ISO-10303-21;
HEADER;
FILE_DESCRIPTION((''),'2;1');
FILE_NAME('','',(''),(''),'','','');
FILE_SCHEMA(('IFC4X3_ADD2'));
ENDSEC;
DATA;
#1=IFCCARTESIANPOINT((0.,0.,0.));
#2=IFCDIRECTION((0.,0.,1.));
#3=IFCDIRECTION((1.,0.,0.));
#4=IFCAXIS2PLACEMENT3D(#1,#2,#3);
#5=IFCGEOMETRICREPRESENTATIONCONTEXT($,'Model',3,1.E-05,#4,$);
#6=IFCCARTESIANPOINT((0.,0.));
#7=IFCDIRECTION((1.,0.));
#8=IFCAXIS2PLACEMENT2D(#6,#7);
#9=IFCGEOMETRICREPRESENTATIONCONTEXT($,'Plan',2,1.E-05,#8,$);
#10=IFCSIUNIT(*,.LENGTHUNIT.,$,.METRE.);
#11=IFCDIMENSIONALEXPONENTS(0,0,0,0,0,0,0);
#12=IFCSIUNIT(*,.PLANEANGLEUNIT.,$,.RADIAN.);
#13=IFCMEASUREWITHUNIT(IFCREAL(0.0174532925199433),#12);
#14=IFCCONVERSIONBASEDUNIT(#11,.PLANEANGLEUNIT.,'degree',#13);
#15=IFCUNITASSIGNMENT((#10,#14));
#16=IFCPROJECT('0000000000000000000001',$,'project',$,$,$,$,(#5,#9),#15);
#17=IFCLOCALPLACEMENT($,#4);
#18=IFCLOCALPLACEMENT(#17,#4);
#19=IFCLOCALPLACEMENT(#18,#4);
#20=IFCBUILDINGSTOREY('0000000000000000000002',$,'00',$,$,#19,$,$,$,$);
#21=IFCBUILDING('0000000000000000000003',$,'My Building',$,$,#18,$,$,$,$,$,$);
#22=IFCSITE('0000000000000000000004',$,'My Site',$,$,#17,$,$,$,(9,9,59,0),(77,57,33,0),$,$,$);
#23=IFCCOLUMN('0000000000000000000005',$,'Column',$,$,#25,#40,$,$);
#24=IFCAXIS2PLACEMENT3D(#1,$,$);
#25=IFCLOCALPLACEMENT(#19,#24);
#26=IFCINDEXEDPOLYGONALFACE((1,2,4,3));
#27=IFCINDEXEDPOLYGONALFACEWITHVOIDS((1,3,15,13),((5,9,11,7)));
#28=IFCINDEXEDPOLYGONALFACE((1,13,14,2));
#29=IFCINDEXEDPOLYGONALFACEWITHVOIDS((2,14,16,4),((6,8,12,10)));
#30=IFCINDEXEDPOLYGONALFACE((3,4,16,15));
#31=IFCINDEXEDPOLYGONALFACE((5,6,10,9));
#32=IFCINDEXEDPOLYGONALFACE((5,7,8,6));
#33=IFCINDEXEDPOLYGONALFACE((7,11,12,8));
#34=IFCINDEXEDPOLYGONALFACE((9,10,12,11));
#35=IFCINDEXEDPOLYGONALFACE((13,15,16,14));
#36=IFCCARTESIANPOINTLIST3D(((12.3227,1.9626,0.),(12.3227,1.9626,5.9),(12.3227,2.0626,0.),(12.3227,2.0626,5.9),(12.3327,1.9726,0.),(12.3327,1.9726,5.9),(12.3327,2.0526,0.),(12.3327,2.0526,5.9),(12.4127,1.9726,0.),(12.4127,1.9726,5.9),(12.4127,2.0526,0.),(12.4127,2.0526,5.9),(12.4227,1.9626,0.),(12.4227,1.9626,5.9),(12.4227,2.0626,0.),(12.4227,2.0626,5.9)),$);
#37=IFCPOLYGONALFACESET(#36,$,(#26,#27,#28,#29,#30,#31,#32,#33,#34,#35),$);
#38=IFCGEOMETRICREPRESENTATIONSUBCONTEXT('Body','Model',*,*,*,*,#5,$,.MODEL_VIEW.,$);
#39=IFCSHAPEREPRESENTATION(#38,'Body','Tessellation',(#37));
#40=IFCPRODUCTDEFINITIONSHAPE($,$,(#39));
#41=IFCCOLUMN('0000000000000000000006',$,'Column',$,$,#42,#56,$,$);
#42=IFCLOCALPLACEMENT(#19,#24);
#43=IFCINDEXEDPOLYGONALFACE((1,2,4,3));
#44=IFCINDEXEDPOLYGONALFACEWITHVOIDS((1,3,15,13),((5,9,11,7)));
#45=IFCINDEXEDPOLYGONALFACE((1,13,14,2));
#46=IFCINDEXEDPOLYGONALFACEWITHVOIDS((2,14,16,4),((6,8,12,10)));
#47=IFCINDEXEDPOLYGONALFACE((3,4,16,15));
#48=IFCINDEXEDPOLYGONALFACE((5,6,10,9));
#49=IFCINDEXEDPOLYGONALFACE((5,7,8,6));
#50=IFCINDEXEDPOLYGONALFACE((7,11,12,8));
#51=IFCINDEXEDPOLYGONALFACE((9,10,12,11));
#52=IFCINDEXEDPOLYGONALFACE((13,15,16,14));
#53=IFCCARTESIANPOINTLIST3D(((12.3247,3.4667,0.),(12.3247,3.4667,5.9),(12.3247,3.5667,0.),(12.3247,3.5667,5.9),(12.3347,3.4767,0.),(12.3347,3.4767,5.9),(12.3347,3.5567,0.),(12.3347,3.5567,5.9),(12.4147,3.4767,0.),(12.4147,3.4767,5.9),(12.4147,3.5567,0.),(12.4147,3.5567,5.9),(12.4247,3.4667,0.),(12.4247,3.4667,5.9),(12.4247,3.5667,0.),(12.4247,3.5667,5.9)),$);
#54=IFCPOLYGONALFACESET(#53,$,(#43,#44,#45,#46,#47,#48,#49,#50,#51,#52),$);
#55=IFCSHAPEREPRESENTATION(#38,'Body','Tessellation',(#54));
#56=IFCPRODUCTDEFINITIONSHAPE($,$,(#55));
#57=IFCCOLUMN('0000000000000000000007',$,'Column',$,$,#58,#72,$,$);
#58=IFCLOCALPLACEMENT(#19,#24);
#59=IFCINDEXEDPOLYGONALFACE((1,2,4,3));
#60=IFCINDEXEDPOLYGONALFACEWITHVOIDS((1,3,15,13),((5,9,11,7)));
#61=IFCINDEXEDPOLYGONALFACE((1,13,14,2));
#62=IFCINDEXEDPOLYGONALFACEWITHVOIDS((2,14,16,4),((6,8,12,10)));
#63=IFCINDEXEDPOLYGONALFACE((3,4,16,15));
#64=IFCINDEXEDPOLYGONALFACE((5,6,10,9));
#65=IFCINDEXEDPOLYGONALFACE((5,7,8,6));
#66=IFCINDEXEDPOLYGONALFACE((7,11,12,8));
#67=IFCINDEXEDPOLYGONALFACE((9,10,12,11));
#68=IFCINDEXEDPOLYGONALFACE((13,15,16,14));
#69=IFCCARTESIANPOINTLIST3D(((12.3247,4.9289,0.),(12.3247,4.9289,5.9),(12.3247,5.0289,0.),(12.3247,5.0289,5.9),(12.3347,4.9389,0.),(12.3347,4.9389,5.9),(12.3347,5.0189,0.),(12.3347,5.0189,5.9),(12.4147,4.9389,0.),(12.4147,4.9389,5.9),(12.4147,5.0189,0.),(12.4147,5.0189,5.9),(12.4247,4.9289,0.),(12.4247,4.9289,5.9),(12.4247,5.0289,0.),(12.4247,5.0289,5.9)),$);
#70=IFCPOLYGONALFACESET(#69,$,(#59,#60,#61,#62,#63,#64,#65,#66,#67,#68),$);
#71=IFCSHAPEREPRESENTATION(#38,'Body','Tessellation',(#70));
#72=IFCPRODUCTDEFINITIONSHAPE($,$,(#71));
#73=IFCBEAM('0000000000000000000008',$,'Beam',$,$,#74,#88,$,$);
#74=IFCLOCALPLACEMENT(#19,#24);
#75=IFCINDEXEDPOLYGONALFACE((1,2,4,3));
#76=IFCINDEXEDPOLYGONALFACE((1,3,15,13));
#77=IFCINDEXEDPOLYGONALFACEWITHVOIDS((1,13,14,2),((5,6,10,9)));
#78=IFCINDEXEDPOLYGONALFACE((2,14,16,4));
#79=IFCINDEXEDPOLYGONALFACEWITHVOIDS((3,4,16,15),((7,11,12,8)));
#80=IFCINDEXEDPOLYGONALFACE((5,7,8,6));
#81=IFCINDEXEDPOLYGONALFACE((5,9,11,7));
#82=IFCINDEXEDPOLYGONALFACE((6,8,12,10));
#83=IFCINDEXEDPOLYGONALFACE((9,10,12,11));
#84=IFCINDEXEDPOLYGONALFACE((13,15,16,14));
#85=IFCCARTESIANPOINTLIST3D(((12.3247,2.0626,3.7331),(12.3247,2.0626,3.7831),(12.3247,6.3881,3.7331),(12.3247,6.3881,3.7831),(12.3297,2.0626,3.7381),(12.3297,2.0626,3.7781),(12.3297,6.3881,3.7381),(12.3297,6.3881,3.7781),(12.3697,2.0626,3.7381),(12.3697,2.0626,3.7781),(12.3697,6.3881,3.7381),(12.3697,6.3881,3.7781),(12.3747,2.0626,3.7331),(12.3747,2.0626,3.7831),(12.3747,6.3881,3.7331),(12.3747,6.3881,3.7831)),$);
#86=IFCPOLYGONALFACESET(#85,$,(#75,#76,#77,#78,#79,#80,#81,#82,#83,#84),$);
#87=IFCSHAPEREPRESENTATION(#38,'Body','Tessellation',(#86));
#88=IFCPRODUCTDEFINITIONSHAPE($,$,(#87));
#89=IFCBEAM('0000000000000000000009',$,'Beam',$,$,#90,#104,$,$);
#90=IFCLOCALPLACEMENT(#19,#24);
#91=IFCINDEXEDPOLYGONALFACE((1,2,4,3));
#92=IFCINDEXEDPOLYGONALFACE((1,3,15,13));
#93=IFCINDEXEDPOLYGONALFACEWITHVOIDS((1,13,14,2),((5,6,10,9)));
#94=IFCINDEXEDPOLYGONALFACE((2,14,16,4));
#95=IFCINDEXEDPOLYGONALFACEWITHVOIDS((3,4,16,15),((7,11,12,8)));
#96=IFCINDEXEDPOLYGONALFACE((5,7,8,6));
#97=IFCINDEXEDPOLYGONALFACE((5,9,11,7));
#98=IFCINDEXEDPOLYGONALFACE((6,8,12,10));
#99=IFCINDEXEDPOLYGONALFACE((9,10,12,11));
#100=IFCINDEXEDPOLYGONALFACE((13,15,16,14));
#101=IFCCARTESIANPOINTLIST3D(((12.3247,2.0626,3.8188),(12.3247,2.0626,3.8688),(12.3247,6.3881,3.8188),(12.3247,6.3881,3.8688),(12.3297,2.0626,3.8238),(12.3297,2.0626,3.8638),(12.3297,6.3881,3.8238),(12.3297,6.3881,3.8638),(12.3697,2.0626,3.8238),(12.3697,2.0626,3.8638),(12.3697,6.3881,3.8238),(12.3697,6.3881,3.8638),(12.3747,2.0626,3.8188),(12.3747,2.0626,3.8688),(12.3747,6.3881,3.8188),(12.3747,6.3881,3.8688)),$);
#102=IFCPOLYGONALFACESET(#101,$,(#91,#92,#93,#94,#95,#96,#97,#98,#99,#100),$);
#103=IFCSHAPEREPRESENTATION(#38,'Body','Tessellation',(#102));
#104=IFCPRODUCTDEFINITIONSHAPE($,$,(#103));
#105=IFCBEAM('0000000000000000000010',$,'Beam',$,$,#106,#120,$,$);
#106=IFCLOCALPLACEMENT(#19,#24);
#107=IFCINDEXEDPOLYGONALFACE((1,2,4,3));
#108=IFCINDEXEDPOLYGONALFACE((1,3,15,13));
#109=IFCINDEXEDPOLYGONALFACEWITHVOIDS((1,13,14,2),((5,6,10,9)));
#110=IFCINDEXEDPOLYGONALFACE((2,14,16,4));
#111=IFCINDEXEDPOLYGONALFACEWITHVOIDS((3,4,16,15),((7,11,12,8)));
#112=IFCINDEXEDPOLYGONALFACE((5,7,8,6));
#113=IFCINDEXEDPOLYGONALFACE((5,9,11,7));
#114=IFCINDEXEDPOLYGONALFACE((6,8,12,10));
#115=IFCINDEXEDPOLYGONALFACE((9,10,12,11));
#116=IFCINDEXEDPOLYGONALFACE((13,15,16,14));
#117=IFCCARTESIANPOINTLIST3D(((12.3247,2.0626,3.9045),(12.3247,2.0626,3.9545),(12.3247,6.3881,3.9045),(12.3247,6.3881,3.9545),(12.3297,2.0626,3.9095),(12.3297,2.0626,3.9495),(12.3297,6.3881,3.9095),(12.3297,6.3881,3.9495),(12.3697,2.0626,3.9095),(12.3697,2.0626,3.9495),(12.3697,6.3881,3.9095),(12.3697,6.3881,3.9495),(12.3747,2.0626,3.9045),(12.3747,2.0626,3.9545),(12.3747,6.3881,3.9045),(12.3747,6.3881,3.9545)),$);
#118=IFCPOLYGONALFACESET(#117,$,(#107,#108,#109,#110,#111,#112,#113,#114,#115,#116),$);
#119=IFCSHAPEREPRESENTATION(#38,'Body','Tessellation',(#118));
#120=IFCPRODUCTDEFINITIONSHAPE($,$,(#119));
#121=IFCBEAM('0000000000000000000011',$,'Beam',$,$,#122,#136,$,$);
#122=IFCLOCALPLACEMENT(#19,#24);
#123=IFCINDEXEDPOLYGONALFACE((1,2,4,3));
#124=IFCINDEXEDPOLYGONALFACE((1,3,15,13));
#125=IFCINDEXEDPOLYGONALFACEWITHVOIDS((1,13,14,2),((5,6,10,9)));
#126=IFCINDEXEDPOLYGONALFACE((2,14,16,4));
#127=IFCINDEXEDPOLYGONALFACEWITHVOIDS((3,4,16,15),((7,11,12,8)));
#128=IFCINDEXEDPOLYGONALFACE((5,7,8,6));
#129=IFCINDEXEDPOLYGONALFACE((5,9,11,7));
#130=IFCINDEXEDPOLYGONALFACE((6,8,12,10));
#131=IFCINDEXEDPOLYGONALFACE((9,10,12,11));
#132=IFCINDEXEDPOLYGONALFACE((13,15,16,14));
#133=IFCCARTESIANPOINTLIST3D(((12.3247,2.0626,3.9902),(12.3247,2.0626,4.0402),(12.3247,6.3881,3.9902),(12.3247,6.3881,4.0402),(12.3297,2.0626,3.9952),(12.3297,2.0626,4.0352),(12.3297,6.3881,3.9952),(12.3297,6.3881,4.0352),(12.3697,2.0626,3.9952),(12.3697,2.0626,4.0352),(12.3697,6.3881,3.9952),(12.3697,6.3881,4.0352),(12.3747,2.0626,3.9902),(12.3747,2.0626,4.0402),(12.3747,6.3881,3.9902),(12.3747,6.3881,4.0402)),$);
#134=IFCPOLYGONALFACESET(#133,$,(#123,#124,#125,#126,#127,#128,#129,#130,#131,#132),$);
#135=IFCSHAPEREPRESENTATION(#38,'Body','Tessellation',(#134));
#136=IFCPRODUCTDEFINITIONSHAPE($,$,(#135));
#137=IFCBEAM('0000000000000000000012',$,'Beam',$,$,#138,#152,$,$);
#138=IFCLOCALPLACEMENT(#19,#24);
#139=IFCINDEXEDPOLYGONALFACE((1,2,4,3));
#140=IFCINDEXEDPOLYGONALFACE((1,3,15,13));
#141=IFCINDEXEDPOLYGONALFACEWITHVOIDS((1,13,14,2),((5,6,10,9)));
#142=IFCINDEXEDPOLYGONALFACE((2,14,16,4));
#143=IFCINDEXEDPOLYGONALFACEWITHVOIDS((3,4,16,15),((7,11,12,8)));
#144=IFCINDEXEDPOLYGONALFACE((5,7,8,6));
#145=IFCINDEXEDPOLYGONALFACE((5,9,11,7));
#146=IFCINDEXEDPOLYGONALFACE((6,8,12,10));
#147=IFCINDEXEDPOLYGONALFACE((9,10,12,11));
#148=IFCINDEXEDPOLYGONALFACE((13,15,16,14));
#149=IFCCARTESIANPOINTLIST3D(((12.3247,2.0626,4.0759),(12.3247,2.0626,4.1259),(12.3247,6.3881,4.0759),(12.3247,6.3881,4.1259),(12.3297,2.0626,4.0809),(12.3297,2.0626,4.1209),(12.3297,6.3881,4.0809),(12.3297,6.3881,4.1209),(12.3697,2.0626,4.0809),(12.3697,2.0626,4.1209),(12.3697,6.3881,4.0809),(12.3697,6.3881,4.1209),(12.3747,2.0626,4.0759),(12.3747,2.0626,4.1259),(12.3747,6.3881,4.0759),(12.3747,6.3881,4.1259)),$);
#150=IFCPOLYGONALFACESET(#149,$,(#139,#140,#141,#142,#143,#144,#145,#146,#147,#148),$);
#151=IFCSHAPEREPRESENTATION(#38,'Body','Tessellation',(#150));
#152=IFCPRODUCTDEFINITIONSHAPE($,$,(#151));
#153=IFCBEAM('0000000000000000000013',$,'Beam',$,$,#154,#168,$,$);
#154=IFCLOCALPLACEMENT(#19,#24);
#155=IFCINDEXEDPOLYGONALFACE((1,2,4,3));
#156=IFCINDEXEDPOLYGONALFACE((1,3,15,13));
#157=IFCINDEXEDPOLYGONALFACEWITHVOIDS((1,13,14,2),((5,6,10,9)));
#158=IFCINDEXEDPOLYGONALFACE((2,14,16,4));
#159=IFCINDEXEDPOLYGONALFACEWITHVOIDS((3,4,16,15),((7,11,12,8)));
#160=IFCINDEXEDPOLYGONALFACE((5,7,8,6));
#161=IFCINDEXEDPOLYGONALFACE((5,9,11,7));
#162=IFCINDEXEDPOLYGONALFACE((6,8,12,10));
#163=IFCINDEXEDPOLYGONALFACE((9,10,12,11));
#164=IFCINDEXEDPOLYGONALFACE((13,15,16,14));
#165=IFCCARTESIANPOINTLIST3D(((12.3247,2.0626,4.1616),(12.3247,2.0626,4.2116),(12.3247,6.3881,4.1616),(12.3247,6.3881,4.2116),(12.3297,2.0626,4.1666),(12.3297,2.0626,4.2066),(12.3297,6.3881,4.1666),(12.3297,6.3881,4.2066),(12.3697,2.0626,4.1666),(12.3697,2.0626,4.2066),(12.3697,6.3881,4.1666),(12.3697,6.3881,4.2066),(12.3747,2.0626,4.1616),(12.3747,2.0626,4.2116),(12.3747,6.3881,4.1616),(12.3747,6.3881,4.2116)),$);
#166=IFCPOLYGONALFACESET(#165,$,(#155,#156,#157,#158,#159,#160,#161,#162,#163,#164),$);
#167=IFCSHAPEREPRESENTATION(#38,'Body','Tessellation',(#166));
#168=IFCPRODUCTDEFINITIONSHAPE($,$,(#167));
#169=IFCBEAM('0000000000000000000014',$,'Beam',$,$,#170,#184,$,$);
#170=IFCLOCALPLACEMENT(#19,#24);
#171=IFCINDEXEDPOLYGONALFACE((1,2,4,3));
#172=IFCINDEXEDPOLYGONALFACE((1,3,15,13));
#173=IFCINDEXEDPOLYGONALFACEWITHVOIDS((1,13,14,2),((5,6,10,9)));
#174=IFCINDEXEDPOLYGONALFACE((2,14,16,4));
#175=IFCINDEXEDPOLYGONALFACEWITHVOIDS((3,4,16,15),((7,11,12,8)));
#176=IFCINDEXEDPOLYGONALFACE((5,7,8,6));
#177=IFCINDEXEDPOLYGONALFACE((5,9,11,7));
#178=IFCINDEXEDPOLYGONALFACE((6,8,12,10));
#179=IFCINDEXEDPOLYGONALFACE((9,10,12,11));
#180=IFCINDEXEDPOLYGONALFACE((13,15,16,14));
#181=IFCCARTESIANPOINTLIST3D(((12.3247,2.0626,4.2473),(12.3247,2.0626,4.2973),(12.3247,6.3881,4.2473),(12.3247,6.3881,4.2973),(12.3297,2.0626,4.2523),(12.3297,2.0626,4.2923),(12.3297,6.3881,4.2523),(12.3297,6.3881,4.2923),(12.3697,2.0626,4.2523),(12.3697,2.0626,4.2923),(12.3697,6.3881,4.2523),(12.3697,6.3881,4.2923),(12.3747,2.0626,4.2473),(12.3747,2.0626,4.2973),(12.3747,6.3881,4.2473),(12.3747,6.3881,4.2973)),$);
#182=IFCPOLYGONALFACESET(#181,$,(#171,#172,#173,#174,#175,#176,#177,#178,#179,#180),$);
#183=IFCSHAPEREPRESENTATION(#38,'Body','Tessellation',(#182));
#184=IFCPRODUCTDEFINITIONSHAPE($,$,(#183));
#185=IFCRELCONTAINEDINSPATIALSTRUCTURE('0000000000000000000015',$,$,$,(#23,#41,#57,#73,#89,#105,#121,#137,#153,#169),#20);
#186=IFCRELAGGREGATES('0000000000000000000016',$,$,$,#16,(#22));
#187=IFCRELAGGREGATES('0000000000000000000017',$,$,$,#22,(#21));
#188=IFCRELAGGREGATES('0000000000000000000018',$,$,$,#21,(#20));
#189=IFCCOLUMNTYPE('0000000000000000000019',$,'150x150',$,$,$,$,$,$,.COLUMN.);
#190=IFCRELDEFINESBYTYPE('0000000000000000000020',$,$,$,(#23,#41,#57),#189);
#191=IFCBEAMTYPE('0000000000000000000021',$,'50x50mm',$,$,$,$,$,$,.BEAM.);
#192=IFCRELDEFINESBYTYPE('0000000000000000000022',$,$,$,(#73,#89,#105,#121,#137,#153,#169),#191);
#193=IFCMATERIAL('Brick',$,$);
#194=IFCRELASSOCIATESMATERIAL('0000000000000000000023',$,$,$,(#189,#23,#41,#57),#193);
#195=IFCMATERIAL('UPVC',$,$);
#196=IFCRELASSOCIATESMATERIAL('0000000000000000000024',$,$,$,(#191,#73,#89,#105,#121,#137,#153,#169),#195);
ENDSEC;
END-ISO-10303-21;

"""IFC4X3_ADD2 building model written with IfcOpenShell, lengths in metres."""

from ifc_helpers import new_model, entity, si_unit, converted_unit, frame, origin_with_axes, origin_2d_with_axis, place, context, subcontext, project, spatial, hollow_rectangle, extrude, material, material_profile, profile_set, profile_usage, type_object, element, save


model = new_model("IFC4X3_ADD2")

# Units and contexts
model_context = context("Model", 3, precision=1e-05, world=origin_with_axes())
plan_context = context("Plan", 2, precision=1e-05, world=origin_2d_with_axis())
body_context = subcontext(model_context, "Body", "Model", "MODEL_VIEW")
ifc_project = project(units=[si_unit("LENGTHUNIT", "METRE"), converted_unit("PLANEANGLEUNIT", "degree", entity("IfcReal", 0.0174532925199433), si_unit("PLANEANGLEUNIT", "RADIAN"), dimensions=[0, 0, 0, 0, 0, 0, 0])], contexts=[model_context, plan_context])

# Site, building, storey
site_placement = place(None, origin_with_axes())
site = spatial("IfcSite", under=ifc_project, at=site_placement, Name="My Site", RefLatitude=(9, 9, 59, 0), RefLongitude=(77, 57, 33, 0))
building_placement = place(site_placement, origin_with_axes())
building = spatial("IfcBuilding", under=site, at=building_placement, Name="My Building")
storey_placement = place(building_placement, origin_with_axes())
storey = spatial("IfcBuildingStorey", under=building, at=storey_placement, Name="00")

# Columns
ifc_material_1 = material(Name="UPVC")
ifc_material_2 = material(Name="Brick")
ifc_material_profile_1 = material_profile(ifc_material_2, hollow_rectangle(XDim=0.1, YDim=0.1, WallThickness=0.01))
ifc_profile_set_1 = profile_set([ifc_material_profile_1])
ifc_profile_usage_1 = profile_usage(ifc_profile_set_1, cardinal=5)
column_type_1 = type_object("IfcColumnType", Name="150x150", PredefinedType="COLUMN", material=ifc_profile_set_1)
column_1_placement = place(storey_placement, frame((12.3727, 2.0126, 0.0), z_axis=(0.0, 0.0, 1.0), x_axis=(1.0, 0.0, 0.0)))
element("IfcColumn", 1, at=column_1_placement, inside=storey, type_object=column_type_1, material=ifc_profile_usage_1, Name="Column", context=body_context, shape_type="SweptSolid", body=[
    extrude(hollow_rectangle(XDim=0.1, YDim=0.1, WallThickness=0.01), origin_with_axes(), (0.0, 0.0, 1.0), 5.9),
])
ifc_profile_usage_2 = profile_usage(ifc_profile_set_1, cardinal=5)
column_2_placement = place(storey_placement, frame((12.3747, 3.5167, 0.0), z_axis=(0.0, 0.0, 1.0), x_axis=(1.0, 0.0, 0.0)))
element("IfcColumn", 2, at=column_2_placement, inside=storey, type_object=column_type_1, material=ifc_profile_usage_2, Name="Column", context=body_context, shape_type="SweptSolid", body=[
    extrude(hollow_rectangle(XDim=0.1, YDim=0.1, WallThickness=0.01), origin_with_axes(), (0.0, 0.0, 1.0), 5.9),
])
ifc_profile_usage_3 = profile_usage(ifc_profile_set_1, cardinal=5)
column_3_placement = place(storey_placement, frame((12.3747, 4.9789, 0.0), z_axis=(0.0, 0.0, 1.0), x_axis=(1.0, 0.0, 0.0)))
element("IfcColumn", 3, at=column_3_placement, inside=storey, type_object=column_type_1, material=ifc_profile_usage_3, Name="Column", context=body_context, shape_type="SweptSolid", body=[
    extrude(hollow_rectangle(XDim=0.1, YDim=0.1, WallThickness=0.01), origin_with_axes(), (0.0, 0.0, 1.0), 5.9),
])

# Beams
ifc_material_profile_2 = material_profile(ifc_material_1, hollow_rectangle(XDim=0.05, YDim=0.05, WallThickness=0.005))
ifc_profile_set_2 = profile_set([ifc_material_profile_2])
ifc_profile_usage_4 = profile_usage(ifc_profile_set_2, cardinal=5)
beam_type = type_object("IfcBeamType", Name="50x50mm", PredefinedType="BEAM", material=ifc_profile_set_2)
beam_1_placement = place(storey_placement, frame((12.3497, 2.0626, 3.7581), z_axis=(0.0, 1.0, 0.000001), x_axis=(-1.0, 0.0, 0.0)))
element("IfcBeam", 4, at=beam_1_placement, inside=storey, type_object=beam_type, material=ifc_profile_usage_4, Name="Beam", context=body_context, shape_type="SweptSolid", body=[
    extrude(hollow_rectangle(XDim=0.05, YDim=0.05, WallThickness=0.005), origin_with_axes(), (0.0, 0.0, 1.0), 4.3255),
])
ifc_profile_usage_5 = profile_usage(ifc_profile_set_2, cardinal=5)
beam_2_placement = place(storey_placement, frame((12.3497, 2.0626, 3.8438), z_axis=(0.0, 1.0, 0.000001), x_axis=(-1.0, 0.0, 0.0)))
element("IfcBeam", 5, at=beam_2_placement, inside=storey, type_object=beam_type, material=ifc_profile_usage_5, Name="Beam", context=body_context, shape_type="SweptSolid", body=[
    extrude(hollow_rectangle(XDim=0.05, YDim=0.05, WallThickness=0.005), origin_with_axes(), (0.0, 0.0, 1.0), 4.3255),
])
ifc_profile_usage_6 = profile_usage(ifc_profile_set_2, cardinal=5)
beam_3_placement = place(storey_placement, frame((12.3497, 2.0626, 3.9295), z_axis=(0.0, 1.0, 0.000001), x_axis=(-1.0, 0.0, 0.0)))
element("IfcBeam", 6, at=beam_3_placement, inside=storey, type_object=beam_type, material=ifc_profile_usage_6, Name="Beam", context=body_context, shape_type="SweptSolid", body=[
    extrude(hollow_rectangle(XDim=0.05, YDim=0.05, WallThickness=0.005), origin_with_axes(), (0.0, 0.0, 1.0), 4.3255),
])
ifc_profile_usage_7 = profile_usage(ifc_profile_set_2, cardinal=5)
beam_4_placement = place(storey_placement, frame((12.3497, 2.0626, 4.0152), z_axis=(0.0, 1.0, 0.000001), x_axis=(-1.0, 0.0, 0.0)))
element("IfcBeam", 7, at=beam_4_placement, inside=storey, type_object=beam_type, material=ifc_profile_usage_7, Name="Beam", context=body_context, shape_type="SweptSolid", body=[
    extrude(hollow_rectangle(XDim=0.05, YDim=0.05, WallThickness=0.005), origin_with_axes(), (0.0, 0.0, 1.0), 4.3255),
])
ifc_profile_usage_8 = profile_usage(ifc_profile_set_2, cardinal=5)
beam_5_placement = place(storey_placement, frame((12.3497, 2.0626, 4.1009), z_axis=(0.0, 1.0, 0.000001), x_axis=(-1.0, 0.0, 0.0)))
element("IfcBeam", 8, at=beam_5_placement, inside=storey, type_object=beam_type, material=ifc_profile_usage_8, Name="Beam", context=body_context, shape_type="SweptSolid", body=[
    extrude(hollow_rectangle(XDim=0.05, YDim=0.05, WallThickness=0.005), origin_with_axes(), (0.0, 0.0, 1.0), 4.3255),
])
ifc_profile_usage_9 = profile_usage(ifc_profile_set_2, cardinal=5)
beam_6_placement = place(storey_placement, frame((12.3497, 2.0626, 4.1866), z_axis=(0.0, 1.0, 0.000001), x_axis=(-1.0, 0.0, 0.0)))
element("IfcBeam", 9, at=beam_6_placement, inside=storey, type_object=beam_type, material=ifc_profile_usage_9, Name="Beam", context=body_context, shape_type="SweptSolid", body=[
    extrude(hollow_rectangle(XDim=0.05, YDim=0.05, WallThickness=0.005), origin_with_axes(), (0.0, 0.0, 1.0), 4.3255),
])
ifc_profile_usage_10 = profile_usage(ifc_profile_set_2, cardinal=5)
beam_7_placement = place(storey_placement, frame((12.3497, 2.0626, 4.2723), z_axis=(0.0, 1.0, 0.000001), x_axis=(-1.0, 0.0, 0.0)))
element("IfcBeam", 10, at=beam_7_placement, inside=storey, type_object=beam_type, material=ifc_profile_usage_10, Name="Beam", context=body_context, shape_type="SweptSolid", body=[
    extrude(hollow_rectangle(XDim=0.05, YDim=0.05, WallThickness=0.005), origin_with_axes(), (0.0, 0.0, 1.0), 4.3255),
])

save(model, "model.ifc")
